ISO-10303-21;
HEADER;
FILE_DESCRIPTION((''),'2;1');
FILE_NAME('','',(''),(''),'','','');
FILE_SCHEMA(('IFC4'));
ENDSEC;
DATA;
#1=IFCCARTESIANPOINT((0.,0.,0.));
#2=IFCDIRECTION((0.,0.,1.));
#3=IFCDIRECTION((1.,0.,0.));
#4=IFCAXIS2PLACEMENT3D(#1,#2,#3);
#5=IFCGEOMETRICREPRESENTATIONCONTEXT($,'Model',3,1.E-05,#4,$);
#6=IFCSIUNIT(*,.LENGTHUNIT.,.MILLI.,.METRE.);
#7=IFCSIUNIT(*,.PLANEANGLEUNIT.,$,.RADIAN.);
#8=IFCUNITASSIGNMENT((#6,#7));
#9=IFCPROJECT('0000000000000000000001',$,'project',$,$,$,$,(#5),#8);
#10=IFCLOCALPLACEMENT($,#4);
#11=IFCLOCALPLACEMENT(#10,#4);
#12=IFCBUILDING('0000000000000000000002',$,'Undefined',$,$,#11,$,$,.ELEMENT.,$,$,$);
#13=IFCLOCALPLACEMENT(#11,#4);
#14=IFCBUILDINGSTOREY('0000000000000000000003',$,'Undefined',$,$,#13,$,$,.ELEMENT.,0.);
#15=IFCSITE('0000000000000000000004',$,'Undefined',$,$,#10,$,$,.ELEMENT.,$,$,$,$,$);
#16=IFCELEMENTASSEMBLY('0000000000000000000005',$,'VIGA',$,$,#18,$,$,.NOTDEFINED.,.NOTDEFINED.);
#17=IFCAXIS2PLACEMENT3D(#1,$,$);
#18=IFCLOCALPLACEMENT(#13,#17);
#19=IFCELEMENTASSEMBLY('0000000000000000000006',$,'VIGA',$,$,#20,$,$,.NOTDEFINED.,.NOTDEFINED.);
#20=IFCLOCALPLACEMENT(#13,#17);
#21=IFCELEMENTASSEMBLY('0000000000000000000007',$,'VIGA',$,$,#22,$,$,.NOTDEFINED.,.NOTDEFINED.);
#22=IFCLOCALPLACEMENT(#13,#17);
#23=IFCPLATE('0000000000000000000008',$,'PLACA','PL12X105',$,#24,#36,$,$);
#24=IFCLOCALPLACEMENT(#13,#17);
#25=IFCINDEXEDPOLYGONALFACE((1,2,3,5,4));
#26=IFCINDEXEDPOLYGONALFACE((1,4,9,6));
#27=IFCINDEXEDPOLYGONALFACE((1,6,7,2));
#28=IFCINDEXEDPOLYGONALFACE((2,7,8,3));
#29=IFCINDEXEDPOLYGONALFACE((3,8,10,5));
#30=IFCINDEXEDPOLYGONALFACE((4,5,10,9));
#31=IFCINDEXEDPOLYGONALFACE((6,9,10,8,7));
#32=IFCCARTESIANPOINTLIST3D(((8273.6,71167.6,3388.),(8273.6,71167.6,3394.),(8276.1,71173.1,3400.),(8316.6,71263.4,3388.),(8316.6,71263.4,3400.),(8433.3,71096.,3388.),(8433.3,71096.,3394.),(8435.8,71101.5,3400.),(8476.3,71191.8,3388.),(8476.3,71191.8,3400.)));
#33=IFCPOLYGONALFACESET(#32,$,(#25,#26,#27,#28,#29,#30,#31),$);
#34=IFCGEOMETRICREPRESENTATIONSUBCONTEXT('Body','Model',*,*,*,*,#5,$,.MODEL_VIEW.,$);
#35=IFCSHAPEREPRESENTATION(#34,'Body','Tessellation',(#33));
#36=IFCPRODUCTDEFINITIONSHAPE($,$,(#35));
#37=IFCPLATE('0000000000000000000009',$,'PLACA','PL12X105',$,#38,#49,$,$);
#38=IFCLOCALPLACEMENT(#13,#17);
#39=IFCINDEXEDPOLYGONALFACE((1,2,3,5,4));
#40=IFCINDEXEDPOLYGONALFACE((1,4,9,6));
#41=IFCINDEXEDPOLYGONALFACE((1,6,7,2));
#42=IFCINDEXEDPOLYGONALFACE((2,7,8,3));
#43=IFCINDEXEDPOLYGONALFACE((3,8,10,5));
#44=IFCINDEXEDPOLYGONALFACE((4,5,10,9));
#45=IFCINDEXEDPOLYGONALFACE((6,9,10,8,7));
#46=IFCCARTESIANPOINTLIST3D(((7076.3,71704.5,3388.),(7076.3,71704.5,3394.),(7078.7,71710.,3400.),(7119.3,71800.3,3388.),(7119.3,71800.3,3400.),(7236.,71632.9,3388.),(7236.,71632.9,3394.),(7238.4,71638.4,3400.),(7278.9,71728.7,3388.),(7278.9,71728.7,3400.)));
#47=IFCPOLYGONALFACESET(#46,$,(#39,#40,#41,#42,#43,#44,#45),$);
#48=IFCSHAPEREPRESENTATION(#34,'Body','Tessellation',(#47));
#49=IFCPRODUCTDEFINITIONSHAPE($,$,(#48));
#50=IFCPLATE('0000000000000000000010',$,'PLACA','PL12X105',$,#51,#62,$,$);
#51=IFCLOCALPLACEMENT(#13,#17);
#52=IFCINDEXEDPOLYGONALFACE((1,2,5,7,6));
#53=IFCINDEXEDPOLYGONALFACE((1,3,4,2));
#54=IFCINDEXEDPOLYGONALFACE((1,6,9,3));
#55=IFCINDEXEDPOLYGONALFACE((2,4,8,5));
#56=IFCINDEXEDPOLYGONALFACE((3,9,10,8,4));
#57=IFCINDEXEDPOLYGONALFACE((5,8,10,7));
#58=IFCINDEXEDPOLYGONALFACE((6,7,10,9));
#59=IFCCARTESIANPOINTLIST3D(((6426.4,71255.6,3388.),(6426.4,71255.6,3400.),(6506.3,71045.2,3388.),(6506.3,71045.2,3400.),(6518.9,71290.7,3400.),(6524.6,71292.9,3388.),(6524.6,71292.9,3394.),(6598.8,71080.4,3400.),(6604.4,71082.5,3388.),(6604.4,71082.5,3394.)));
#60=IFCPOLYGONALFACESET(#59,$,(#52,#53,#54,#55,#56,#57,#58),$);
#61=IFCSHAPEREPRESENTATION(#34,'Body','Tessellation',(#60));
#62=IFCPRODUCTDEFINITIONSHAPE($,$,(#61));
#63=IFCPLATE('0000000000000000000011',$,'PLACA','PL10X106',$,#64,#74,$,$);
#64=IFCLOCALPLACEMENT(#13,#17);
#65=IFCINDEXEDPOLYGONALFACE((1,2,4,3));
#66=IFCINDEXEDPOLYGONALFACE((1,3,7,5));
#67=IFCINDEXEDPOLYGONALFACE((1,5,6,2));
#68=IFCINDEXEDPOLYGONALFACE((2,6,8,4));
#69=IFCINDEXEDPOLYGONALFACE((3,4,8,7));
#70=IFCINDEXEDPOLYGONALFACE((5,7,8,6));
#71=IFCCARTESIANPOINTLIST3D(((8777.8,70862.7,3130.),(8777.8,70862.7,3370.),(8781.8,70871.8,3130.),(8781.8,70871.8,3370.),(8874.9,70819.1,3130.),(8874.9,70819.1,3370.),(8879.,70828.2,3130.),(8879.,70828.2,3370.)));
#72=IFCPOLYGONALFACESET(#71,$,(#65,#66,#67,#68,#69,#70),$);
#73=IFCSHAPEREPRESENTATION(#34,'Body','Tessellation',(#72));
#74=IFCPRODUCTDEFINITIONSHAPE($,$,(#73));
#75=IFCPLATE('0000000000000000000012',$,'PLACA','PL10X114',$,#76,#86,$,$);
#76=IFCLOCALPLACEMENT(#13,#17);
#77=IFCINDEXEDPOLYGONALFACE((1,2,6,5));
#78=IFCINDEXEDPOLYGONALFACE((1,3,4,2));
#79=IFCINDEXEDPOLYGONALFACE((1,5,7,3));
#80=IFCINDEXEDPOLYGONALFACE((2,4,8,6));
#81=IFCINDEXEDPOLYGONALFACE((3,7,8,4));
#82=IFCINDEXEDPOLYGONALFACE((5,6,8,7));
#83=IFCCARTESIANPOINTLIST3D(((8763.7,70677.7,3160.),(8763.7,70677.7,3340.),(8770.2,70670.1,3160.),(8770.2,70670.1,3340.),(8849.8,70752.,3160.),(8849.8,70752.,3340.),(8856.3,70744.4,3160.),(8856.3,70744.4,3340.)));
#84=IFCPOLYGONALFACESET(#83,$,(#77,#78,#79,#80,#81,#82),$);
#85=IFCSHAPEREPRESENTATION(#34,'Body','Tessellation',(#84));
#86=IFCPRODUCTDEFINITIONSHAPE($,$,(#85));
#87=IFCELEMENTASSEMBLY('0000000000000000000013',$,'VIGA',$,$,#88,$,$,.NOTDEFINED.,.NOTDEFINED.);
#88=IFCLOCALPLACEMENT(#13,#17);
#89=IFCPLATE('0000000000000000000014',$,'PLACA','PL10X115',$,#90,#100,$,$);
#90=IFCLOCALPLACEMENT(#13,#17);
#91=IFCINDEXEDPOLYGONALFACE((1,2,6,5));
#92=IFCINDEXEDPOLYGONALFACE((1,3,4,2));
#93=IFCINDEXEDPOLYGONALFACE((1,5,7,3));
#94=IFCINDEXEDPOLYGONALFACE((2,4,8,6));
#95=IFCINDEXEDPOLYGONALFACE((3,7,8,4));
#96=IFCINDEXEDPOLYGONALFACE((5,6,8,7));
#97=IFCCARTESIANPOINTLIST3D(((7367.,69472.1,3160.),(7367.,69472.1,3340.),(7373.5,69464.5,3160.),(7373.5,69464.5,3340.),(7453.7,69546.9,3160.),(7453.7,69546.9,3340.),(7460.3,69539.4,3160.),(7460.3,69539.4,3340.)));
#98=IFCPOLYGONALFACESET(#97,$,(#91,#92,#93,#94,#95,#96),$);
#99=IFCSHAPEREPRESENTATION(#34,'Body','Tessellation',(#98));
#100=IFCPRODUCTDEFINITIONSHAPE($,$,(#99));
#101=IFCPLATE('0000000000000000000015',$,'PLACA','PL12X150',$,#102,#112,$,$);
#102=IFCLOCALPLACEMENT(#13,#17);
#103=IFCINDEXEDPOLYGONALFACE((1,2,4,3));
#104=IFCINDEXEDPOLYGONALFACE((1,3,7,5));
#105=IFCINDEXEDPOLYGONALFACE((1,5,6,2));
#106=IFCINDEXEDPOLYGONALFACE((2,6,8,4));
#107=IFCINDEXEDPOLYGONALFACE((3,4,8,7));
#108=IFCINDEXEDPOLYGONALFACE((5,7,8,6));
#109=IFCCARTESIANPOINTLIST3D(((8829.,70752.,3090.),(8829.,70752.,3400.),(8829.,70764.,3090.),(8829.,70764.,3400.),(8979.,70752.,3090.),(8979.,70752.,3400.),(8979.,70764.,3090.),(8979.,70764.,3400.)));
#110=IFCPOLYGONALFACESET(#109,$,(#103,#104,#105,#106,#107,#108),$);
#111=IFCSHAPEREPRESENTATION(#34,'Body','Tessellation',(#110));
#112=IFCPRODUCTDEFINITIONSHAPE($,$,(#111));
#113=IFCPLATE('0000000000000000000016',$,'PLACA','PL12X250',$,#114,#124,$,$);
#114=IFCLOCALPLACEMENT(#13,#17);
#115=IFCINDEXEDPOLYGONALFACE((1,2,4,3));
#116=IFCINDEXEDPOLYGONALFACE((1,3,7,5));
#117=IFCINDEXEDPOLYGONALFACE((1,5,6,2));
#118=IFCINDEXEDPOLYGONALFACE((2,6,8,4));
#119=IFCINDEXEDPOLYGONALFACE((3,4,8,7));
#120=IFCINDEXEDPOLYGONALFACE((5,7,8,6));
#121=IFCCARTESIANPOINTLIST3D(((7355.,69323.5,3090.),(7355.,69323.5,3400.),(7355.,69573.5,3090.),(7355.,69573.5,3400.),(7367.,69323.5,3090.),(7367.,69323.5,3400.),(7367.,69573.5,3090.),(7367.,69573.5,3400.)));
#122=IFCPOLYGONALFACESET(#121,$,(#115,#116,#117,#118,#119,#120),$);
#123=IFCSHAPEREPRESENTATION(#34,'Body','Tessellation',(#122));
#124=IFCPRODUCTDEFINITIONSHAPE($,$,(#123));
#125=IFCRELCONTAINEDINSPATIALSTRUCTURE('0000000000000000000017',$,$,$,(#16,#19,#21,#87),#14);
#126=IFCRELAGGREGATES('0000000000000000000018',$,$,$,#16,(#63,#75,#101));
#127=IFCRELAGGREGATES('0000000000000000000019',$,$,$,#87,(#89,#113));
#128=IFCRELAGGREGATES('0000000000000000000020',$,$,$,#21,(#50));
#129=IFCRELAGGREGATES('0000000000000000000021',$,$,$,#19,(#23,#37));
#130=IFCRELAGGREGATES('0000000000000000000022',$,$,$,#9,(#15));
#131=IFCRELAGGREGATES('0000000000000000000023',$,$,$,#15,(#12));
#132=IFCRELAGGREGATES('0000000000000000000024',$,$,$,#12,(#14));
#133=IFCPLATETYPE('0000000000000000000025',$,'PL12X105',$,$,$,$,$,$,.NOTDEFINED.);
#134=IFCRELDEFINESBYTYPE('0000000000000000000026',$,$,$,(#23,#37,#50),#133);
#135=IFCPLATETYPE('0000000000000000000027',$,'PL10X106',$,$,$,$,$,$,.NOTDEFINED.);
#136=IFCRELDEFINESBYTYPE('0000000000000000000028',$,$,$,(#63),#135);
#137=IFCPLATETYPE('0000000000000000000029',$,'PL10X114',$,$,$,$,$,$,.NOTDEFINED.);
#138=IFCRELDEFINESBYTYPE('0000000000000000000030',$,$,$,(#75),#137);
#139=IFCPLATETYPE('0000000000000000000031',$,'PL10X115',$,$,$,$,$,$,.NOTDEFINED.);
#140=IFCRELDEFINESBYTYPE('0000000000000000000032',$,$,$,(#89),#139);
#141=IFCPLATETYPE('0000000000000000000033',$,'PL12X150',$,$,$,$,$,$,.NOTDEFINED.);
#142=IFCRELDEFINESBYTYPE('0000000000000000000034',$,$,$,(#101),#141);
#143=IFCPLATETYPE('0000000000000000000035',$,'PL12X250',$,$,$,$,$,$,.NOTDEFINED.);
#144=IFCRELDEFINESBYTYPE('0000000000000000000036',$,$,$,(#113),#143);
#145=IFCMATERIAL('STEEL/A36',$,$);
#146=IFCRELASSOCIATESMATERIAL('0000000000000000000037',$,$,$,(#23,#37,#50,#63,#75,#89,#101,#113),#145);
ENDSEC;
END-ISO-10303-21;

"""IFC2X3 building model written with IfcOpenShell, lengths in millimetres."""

from ifc_helpers import new_model, si_unit, frame, origin_with_axes, origin_2d_with_axis, place, context, subcontext, project, spatial, polyline, rectangle, outline, extrude, boolean, material, type_object, element, aggregate, save


model = new_model("IFC2X3")

# Units and contexts
model_context = context("Model", 3, precision=1e-05, world=origin_with_axes())
body_context = subcontext(model_context, "Body", "Model", "MODEL_VIEW")
ifc_project = project(units=[si_unit("LENGTHUNIT", "METRE", prefix="MILLI"), si_unit("PLANEANGLEUNIT", "RADIAN")], contexts=[model_context])

# Site, building, storey
site_placement = place(None, origin_with_axes())
site = spatial("IfcSite", under=ifc_project, at=site_placement, Name="Undefined", CompositionType="ELEMENT")
building_placement = place(site_placement, origin_with_axes())
building = spatial("IfcBuilding", under=site, at=building_placement, Name="Undefined", CompositionType="ELEMENT")
storey_placement = place(building_placement, origin_with_axes())
storey = spatial("IfcBuildingStorey", under=building, at=storey_placement, Name="Undefined", CompositionType="ELEMENT", Elevation=0.0)

# Shared definitions
ifc_material_1 = material(Name="STEEL/A36")

# Element assemblies
assembly_1_placement = place(storey_placement, origin_with_axes())
assembly_1 = element("IfcElementAssembly", 1, at=assembly_1_placement, inside=storey, Name="VIGA", AssemblyPlace="NOTDEFINED", PredefinedType="NOTDEFINED")
assembly_2_placement = place(storey_placement, origin_with_axes())
assembly_2 = element("IfcElementAssembly", 2, at=assembly_2_placement, inside=storey, Name="VIGA", AssemblyPlace="NOTDEFINED", PredefinedType="NOTDEFINED")

# Element assembly
assembly_3_placement = place(storey_placement, origin_with_axes())
assembly_3 = element("IfcElementAssembly", 3, at=assembly_3_placement, inside=storey, Name="VIGA", AssemblyPlace="NOTDEFINED", PredefinedType="NOTDEFINED")

# Plates
plate_type_1 = type_object("IfcPlateType", Name="PL12X105", PredefinedType="NOTDEFINED")
plate_1_placement = place(assembly_2_placement, frame((8433.3, 71096.0, 3394.0), z_axis=(0.0, 0.0, -1.0), x_axis=(-0.912465, 0.409155, 0.0)))
plate_1 = element("IfcPlate", 4, at=plate_1_placement, type_object=plate_type_1, material=ifc_material_1, Name="PLACA", Description="PL12X105", context=body_context, shape_type="CSG", body=[
    boolean("DIFFERENCE", extrude(outline(polyline([(0.0, 0.0), (175.0, 0.0), (175.0, 105.0), (0.0, 105.0), (0.0, 0.0)])), frame((0.0, 0.0, -6.0), z_axis=(0.0, 0.0, 1.0), x_axis=(1.0, 0.0, 0.0)), (0.0, 0.0, 1.0), 12.0), extrude(outline(polyline([(0.0, 0.0), (6.0, 0.0), (6.0, 6.0), (0.0, 0.0)])), frame((178.0, 6.0, -6.0), z_axis=(-1.0, 0.0, 0.0), x_axis=(0.0, -1.0, 0.0)), (0.0, 0.0, 1.0), 181.0)),
])
plate_2_placement = place(assembly_2_placement, frame((7236.0, 71632.9, 3394.0), z_axis=(0.0, 0.0, -1.0), x_axis=(-0.912465, 0.409155, 0.0)))
plate_2 = element("IfcPlate", 5, at=plate_2_placement, type_object=plate_type_1, material=ifc_material_1, Name="PLACA", Description="PL12X105", context=body_context, shape_type="CSG", body=[
    boolean("DIFFERENCE", extrude(outline(polyline([(0.0, 0.0), (175.0, 0.0), (175.0, 105.0), (0.0, 105.0), (0.0, 0.0)])), frame((0.0, 0.0, -6.0), z_axis=(0.0, 0.0, 1.0), x_axis=(1.0, 0.0, 0.0)), (0.0, 0.0, 1.0), 12.0), extrude(outline(polyline([(0.0, 0.0), (6.0, 0.0), (6.0, 6.0), (0.0, 0.0)])), frame((178.0, 6.0, -6.0), z_axis=(-1.0, 0.0, 0.0), x_axis=(0.0, -1.0, 0.0)), (0.0, 0.0, 1.0), 181.0)),
])
plate_3_placement = place(assembly_3_placement, frame((6604.4, 71082.5, 3394.0), z_axis=(0.0, 0.0, 1.0), x_axis=(-0.354934, 0.934891, 0.0)))
plate_3 = element("IfcPlate", 6, at=plate_3_placement, type_object=plate_type_1, material=ifc_material_1, Name="PLACA", Description="PL12X105", context=body_context, shape_type="CSG", body=[
    boolean("DIFFERENCE", extrude(outline(polyline([(0.0, 0.0), (225.0, 0.0), (225.0, 105.0), (0.0, 105.0), (0.0, 0.0)])), frame((0.0, 0.0, -6.0), z_axis=(0.0, 0.0, 1.0), x_axis=(1.0, 0.0, 0.0)), (0.0, 0.0, 1.0), 12.0), extrude(outline(polyline([(0.0, 0.0), (6.0, 0.0), (6.0, 6.0), (0.0, 0.0)])), frame((-62.5, 6.0, 6.0), z_axis=(1.0, 0.0, 0.0), x_axis=(0.0, -1.0, 0.0)), (0.0, 0.0, 1.0), 300.0)),
])
plate_type_2 = type_object("IfcPlateType", Name="PL10X106", PredefinedType="NOTDEFINED")
plate_4_placement = place(assembly_1_placement, frame((8877.0, 70823.7, 3370.0), z_axis=(0.409155, 0.912465, 0.0), x_axis=(0.0, 0.0, -1.0)))
plate_4 = element("IfcPlate", 7, at=plate_4_placement, type_object=plate_type_2, material=ifc_material_1, Name="PLACA", Description="PL10X106", context=body_context, shape_type="SweptSolid", body=[
    extrude(outline(polyline([(0.0, 0.0), (240.0, 0.0), (240.0, 106.5), (0.0, 106.5), (0.0, 0.0)])), frame((0.0, 0.0, -5.0), z_axis=(0.0, 0.0, 1.0), x_axis=(1.0, 0.0, 0.0)), (0.0, 0.0, 1.0), 10.0),
])
plate_type_3 = type_object("IfcPlateType", Name="PL10X114", PredefinedType="NOTDEFINED")
plate_5_placement = place(assembly_1_placement, frame((8853.1, 70748.2, 3340.0), z_axis=(-0.653426, 0.756991, 0.0), x_axis=(0.0, 0.0, -1.0)))
plate_5 = element("IfcPlate", 8, at=plate_5_placement, type_object=plate_type_3, material=ifc_material_1, Name="PLACA", Description="PL10X114", context=body_context, shape_type="SweptSolid", body=[
    extrude(outline(polyline([(0.0, 0.0), (180.0, 0.0), (180.0, 113.7), (0.0, 113.7), (0.0, 0.0)])), frame((0.0, 0.0, -5.0), z_axis=(0.0, 0.0, 1.0), x_axis=(1.0, 0.0, 0.0)), (0.0, 0.0, 1.0), 10.0),
])

# Element assembly, plate
assembly_4_placement = place(storey_placement, origin_with_axes())
assembly_4 = element("IfcElementAssembly", 9, at=assembly_4_placement, inside=storey, Name="VIGA", AssemblyPlace="NOTDEFINED", PredefinedType="NOTDEFINED")
plate_type_4 = type_object("IfcPlateType", Name="PL10X115", PredefinedType="NOTDEFINED")
plate_6_placement = place(assembly_4_placement, frame((7370.3, 69468.3, 3340.0), z_axis=(0.653426, -0.756991, 0.0), x_axis=(0.0, 0.0, -1.0)))
plate_6 = element("IfcPlate", 10, at=plate_6_placement, type_object=plate_type_4, material=ifc_material_1, Name="PLACA", Description="PL10X115", context=body_context, shape_type="SweptSolid", body=[
    extrude(outline(polyline([(0.0, 0.0), (180.0, 0.0), (180.0, 114.6), (0.0, 114.6), (0.0, 0.0)])), frame((0.0, 0.0, -5.0), z_axis=(0.0, 0.0, 1.0), x_axis=(1.0, 0.0, 0.0)), (0.0, 0.0, 1.0), 10.0),
])

# Plates
plate_type_5 = type_object("IfcPlateType", Name="PL12X150", PredefinedType="NOTDEFINED")
plate_7_placement = place(assembly_1_placement, frame((8904.0, 70758.0, 3400.0), z_axis=(1.0, 0.0, 0.0), x_axis=(0.0, 0.0, -1.0)))
plate_7 = element("IfcPlate", 11, at=plate_7_placement, type_object=plate_type_5, material=ifc_material_1, Name="PLACA", Description="PL12X150", context=body_context, shape_type="SweptSolid", body=[
    extrude(rectangle(XDim=12.0, YDim=150.0, at=origin_2d_with_axis()), frame((310.0, 0.0, 0.0), z_axis=(-1.0, 0.0, 0.0), x_axis=(0.0, -1.0, 0.0)), (0.0, 0.0, 1.0), 310.0),
])
aggregate(assembly_1, [plate_4, plate_5, plate_7])
plate_type_6 = type_object("IfcPlateType", Name="PL12X250", PredefinedType="NOTDEFINED")
plate_8_placement = place(assembly_4_placement, frame((7361.0, 69448.5, 3400.0), z_axis=(0.0, 1.0, 0.0), x_axis=(0.0, 0.0, -1.0)))
plate_8 = element("IfcPlate", 12, at=plate_8_placement, type_object=plate_type_6, material=ifc_material_1, Name="PLACA", Description="PL12X250", context=body_context, shape_type="SweptSolid", body=[
    extrude(rectangle(XDim=12.0, YDim=250.0, at=origin_2d_with_axis()), frame((310.0, 0.0, 0.0), z_axis=(-1.0, 0.0, 0.0), x_axis=(0.0, -1.0, 0.0)), (0.0, 0.0, 1.0), 310.0),
])
aggregate(assembly_4, [plate_6, plate_8])

aggregate(assembly_3, [plate_3])

aggregate(assembly_2, [plate_1, plate_2])

save(model, "model.ifc")
